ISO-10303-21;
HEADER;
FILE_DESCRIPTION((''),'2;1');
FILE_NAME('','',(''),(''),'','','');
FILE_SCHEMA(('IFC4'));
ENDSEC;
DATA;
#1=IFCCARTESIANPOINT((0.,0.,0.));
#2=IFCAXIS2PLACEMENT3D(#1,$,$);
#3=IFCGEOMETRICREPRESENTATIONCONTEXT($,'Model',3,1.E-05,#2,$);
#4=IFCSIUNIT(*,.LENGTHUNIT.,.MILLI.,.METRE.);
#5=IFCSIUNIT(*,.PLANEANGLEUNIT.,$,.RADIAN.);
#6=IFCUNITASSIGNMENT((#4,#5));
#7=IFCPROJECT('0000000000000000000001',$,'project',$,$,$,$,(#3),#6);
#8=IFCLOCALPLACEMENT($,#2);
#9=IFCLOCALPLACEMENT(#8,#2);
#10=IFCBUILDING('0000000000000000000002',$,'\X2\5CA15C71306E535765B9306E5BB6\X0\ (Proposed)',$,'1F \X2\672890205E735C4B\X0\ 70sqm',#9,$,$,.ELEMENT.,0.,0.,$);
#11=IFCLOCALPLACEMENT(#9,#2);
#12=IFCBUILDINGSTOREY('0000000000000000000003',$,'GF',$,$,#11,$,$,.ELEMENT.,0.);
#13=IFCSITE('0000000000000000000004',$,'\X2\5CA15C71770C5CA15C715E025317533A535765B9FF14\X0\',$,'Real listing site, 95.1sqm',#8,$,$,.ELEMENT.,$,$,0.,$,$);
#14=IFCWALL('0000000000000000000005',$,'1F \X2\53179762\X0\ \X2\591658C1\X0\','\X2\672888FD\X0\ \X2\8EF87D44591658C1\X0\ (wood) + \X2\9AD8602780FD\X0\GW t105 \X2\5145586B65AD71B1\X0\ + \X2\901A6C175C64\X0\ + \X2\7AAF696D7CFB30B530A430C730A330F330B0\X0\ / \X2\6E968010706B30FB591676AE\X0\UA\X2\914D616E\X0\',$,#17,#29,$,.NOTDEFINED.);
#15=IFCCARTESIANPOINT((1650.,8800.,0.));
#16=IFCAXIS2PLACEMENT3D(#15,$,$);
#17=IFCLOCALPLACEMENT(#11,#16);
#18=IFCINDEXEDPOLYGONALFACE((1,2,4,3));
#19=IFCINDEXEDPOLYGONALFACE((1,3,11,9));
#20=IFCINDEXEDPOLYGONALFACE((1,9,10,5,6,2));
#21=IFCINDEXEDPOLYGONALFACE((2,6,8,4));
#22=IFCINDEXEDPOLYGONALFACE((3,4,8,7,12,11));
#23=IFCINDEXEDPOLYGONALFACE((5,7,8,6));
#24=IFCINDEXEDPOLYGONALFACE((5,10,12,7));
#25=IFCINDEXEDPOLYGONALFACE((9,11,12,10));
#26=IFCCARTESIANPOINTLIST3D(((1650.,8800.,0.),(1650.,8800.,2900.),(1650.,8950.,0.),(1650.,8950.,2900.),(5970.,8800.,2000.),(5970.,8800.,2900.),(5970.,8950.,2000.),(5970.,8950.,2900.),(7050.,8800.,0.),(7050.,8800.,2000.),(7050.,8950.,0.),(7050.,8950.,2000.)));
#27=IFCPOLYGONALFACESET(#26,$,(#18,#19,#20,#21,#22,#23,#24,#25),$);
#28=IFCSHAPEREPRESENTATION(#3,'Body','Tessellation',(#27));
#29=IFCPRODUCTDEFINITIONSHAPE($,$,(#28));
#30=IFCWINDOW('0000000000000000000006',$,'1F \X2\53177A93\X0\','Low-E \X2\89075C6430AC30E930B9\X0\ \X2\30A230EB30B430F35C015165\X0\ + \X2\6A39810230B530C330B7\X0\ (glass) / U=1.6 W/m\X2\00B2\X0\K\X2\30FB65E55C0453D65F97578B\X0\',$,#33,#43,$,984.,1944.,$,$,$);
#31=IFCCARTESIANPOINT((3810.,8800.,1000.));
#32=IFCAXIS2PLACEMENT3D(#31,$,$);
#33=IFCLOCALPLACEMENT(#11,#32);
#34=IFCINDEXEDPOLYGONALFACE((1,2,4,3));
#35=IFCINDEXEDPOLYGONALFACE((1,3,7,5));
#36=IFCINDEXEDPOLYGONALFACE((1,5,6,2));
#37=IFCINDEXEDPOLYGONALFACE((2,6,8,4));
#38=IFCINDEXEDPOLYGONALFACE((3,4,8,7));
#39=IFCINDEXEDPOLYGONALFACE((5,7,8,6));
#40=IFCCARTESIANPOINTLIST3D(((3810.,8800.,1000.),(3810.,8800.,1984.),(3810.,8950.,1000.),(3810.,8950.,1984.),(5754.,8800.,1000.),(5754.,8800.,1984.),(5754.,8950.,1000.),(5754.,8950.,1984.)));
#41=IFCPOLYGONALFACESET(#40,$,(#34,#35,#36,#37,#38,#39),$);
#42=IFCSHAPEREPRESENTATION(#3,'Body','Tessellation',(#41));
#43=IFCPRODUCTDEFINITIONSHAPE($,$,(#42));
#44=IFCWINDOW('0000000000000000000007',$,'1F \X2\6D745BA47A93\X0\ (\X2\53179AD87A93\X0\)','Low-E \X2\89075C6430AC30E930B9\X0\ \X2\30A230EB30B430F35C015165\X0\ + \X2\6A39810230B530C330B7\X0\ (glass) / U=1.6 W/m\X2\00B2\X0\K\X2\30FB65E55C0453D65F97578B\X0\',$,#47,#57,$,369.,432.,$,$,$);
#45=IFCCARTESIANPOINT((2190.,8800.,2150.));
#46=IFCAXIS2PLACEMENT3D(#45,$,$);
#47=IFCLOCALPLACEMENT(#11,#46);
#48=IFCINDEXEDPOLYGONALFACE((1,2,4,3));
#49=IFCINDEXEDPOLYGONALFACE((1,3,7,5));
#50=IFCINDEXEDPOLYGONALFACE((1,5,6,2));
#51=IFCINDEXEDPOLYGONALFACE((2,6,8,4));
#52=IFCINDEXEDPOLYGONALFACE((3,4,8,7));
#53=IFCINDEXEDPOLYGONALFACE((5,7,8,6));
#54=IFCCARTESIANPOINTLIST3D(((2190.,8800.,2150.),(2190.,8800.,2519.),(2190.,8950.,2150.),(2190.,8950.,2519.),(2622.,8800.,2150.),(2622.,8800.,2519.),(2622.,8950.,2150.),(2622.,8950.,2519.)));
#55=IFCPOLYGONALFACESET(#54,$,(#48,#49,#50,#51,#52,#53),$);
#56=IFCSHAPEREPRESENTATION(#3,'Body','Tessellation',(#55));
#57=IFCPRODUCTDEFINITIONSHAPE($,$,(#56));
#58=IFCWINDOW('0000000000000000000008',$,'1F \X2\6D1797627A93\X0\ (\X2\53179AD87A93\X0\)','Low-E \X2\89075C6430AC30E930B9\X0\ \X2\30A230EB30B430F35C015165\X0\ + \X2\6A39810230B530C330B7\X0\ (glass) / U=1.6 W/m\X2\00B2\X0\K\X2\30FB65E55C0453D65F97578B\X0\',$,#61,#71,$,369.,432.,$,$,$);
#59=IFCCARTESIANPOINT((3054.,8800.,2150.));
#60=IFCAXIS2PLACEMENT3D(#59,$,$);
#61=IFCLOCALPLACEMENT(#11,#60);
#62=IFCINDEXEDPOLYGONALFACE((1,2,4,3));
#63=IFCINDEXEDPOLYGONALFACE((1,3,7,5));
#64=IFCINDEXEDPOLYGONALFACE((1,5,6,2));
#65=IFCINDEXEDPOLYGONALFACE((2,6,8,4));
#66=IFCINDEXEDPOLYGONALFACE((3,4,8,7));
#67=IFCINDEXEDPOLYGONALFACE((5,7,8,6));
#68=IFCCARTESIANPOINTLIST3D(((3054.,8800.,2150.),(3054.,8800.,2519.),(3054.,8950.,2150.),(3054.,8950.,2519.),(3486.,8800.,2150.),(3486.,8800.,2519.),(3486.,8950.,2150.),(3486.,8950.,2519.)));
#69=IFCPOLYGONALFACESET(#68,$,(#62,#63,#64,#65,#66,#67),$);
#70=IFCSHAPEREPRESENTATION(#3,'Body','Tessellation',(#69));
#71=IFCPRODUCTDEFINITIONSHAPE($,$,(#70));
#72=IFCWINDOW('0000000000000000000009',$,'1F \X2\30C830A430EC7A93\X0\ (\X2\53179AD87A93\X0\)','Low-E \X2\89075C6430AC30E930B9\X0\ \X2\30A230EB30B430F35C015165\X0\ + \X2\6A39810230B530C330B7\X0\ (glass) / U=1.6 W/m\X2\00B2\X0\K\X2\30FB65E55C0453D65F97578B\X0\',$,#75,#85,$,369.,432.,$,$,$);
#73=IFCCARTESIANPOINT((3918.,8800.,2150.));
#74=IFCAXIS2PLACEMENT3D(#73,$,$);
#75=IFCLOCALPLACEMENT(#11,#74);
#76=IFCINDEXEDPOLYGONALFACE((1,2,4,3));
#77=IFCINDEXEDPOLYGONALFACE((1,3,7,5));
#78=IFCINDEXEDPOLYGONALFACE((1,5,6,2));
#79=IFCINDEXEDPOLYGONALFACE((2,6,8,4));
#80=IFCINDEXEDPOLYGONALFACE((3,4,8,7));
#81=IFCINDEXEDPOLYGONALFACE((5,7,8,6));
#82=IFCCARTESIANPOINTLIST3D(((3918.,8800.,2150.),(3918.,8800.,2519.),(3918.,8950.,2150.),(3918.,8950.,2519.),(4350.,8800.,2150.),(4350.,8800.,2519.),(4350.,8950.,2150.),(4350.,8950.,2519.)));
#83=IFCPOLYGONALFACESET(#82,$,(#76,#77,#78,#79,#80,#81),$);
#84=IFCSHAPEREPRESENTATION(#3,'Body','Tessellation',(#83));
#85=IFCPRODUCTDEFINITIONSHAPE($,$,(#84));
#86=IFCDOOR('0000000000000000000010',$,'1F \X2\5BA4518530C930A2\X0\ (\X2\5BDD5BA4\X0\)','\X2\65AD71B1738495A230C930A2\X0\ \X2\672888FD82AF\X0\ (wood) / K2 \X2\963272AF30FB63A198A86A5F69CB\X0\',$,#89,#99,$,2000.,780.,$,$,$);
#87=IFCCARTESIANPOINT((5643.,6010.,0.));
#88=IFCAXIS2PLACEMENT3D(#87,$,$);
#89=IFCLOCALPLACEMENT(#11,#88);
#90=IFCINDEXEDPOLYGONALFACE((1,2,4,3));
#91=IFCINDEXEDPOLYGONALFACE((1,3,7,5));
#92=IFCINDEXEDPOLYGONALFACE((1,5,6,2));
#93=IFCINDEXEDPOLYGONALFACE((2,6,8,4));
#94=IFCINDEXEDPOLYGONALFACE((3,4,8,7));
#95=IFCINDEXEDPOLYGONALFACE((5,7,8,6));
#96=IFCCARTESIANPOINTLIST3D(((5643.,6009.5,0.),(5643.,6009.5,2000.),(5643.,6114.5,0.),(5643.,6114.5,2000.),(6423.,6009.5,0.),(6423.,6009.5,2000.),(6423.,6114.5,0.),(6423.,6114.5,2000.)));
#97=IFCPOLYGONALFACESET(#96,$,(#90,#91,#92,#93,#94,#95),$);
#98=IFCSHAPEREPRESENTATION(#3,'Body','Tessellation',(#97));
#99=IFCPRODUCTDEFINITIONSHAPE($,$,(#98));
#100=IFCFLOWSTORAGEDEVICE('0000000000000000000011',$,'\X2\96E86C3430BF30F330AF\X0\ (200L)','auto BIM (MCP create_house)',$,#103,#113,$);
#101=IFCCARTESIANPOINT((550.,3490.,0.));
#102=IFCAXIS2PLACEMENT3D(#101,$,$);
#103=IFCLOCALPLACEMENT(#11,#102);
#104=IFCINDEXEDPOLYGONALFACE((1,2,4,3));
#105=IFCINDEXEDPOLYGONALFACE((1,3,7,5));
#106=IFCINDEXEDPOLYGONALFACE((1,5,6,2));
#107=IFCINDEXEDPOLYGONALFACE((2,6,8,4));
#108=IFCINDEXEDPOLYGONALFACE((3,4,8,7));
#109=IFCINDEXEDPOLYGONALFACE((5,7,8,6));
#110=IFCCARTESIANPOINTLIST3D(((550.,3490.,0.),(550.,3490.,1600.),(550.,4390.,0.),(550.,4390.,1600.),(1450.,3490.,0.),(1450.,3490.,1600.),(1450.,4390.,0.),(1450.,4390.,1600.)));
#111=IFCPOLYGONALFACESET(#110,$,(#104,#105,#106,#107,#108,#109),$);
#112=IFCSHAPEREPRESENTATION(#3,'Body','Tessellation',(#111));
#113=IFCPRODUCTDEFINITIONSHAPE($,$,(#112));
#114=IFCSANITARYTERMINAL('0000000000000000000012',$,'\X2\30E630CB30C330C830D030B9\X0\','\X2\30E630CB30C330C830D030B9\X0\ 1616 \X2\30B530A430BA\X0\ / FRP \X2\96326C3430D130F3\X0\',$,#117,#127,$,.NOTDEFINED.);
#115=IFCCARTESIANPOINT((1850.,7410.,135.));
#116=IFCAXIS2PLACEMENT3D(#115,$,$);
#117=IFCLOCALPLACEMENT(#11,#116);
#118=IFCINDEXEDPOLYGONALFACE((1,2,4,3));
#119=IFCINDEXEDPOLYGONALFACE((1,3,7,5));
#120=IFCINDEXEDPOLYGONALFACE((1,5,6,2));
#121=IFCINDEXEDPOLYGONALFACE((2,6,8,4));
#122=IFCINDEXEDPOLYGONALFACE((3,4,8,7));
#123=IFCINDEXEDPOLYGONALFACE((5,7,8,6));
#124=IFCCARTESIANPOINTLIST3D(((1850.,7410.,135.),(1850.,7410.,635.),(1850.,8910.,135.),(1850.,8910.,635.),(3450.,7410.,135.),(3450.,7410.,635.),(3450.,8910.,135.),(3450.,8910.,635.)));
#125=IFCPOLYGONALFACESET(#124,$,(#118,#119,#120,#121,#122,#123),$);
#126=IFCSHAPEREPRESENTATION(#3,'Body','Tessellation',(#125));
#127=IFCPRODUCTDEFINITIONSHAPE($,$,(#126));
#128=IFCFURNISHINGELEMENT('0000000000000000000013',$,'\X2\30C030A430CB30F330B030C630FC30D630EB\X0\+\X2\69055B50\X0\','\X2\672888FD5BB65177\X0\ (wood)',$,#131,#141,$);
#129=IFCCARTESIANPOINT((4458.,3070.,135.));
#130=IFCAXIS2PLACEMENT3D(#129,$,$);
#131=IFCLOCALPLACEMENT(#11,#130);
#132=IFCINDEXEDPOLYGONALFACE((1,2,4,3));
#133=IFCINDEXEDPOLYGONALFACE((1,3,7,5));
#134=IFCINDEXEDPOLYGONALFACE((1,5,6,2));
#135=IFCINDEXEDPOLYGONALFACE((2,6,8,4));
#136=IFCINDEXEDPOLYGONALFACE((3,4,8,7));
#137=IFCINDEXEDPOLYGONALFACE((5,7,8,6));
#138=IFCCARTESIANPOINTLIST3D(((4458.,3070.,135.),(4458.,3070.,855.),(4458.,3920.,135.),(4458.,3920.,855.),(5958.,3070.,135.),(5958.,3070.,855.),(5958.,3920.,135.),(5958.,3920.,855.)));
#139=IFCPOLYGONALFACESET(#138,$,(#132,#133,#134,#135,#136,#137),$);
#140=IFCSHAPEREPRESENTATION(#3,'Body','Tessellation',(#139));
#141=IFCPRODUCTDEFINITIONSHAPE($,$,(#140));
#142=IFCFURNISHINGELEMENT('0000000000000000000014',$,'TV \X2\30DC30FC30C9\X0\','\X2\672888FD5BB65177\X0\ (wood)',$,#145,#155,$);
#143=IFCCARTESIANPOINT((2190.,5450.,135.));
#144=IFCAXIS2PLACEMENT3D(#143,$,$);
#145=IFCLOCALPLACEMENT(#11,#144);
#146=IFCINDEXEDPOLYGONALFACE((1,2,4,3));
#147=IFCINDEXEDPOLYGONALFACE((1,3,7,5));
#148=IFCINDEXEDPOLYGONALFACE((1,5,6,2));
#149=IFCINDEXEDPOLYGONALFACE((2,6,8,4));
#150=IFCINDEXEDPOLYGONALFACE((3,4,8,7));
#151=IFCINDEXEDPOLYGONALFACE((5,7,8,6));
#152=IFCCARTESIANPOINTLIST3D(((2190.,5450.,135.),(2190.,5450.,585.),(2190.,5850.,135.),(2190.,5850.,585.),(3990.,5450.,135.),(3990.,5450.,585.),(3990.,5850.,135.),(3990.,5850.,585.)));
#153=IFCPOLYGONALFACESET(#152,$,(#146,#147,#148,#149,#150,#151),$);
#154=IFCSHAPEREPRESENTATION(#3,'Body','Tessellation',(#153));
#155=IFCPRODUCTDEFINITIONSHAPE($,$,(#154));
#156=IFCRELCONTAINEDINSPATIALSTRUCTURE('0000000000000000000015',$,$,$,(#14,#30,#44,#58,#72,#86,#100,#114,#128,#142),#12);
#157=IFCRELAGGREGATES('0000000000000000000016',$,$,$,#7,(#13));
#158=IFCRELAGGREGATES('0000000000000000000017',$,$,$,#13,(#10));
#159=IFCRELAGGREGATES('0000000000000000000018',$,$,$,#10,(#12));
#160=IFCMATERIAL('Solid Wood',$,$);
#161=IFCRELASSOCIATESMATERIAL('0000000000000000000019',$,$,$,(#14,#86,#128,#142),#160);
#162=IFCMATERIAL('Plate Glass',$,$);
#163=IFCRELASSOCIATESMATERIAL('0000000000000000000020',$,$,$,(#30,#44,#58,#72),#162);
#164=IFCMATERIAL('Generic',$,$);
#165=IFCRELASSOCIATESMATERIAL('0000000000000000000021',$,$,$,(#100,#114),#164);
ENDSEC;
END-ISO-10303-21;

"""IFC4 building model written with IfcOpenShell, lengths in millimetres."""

from ifc_helpers import new_model, si_unit, frame, frame_2d, origin, place, context, project, spatial, rectangle, extrude, material, element, fill, save


model = new_model("IFC4")

# Units and contexts
model_context = context("Model", 3, precision=1e-05, world=origin())
ifc_project = project(units=[si_unit("LENGTHUNIT", "METRE", prefix="MILLI"), si_unit("PLANEANGLEUNIT", "RADIAN")], contexts=[model_context])

# Site, building, storey
site_placement = place(None, origin())
site = spatial("IfcSite", under=ifc_project, at=site_placement, Name="岡山県岡山市北区南方４", ObjectType="Real listing site, 95.1sqm", CompositionType="ELEMENT", RefElevation=0.0)
building_placement = place(site_placement, origin())
building = spatial("IfcBuilding", under=site, at=building_placement, Name="岡山の南方の家 (Proposed)", ObjectType="1F 木造平屋 70sqm", CompositionType="ELEMENT", ElevationOfRefHeight=0.0, ElevationOfTerrain=0.0)
storey_placement = place(building_placement, origin())
storey = spatial("IfcBuildingStorey", under=building, at=storey_placement, Name="GF", CompositionType="ELEMENT", Elevation=0.0)

# Wall, openings, windows
ifc_material_1 = material(Name="Solid Wood")
wall_1_placement = place(storey_placement, frame((1650.0, 8800.0, 0.0)))
wall_1 = element("IfcWall", 1, at=wall_1_placement, inside=storey, material=ifc_material_1, Name="1F 北面 外壁", Description="木製 軸組外壁 (wood) + 高性能GW t105 充填断熱 + 通気層 + 窯業系サイディング / 準耐火・外皮UA配慮", PredefinedType="NOTDEFINED", context=model_context, shape_type="SweptSolid", body=[
    extrude(rectangle(XDim=5400.0, YDim=150.0, at=frame_2d((2700.0, 75.0))), frame((1650.0, 8800.0, 0.0)), (0.0, 0.0, 1.0), 2900.0),
])
opening_1_placement = place(storey_placement, frame((3810.0, 8800.0, 1000.0)))
opening_1 = element("IfcOpeningElement", 2, at=opening_1_placement, cuts=wall_1, PredefinedType="NOTDEFINED", context=model_context, shape_type="SweptSolid", body=[
    extrude(rectangle(XDim=1944.0, YDim=150.0, at=frame_2d((972.0, 75.0))), frame((3810.0, 8800.0, 1000.0)), (0.0, 0.0, 1.0), 984.0),
])
opening_2_placement = place(storey_placement, frame((2190.0, 8800.0, 2150.0)))
opening_2 = element("IfcOpeningElement", 3, at=opening_2_placement, cuts=wall_1, PredefinedType="NOTDEFINED", context=model_context, shape_type="SweptSolid", body=[
    extrude(rectangle(XDim=432.0, YDim=150.0, at=frame_2d((216.0, 75.0))), frame((2190.0, 8800.0, 2150.0)), (0.0, 0.0, 1.0), 369.0),
])
opening_3_placement = place(storey_placement, frame((3054.0, 8800.0, 2150.0)))
opening_3 = element("IfcOpeningElement", 4, at=opening_3_placement, cuts=wall_1, PredefinedType="NOTDEFINED", context=model_context, shape_type="SweptSolid", body=[
    extrude(rectangle(XDim=432.0, YDim=150.0, at=frame_2d((216.0, 75.0))), frame((3054.0, 8800.0, 2150.0)), (0.0, 0.0, 1.0), 369.0),
])
opening_4_placement = place(storey_placement, frame((3918.0, 8800.0, 2150.0)))
opening_4 = element("IfcOpeningElement", 5, at=opening_4_placement, cuts=wall_1, PredefinedType="NOTDEFINED", context=model_context, shape_type="SweptSolid", body=[
    extrude(rectangle(XDim=432.0, YDim=150.0, at=frame_2d((216.0, 75.0))), frame((3918.0, 8800.0, 2150.0)), (0.0, 0.0, 1.0), 369.0),
])
ifc_material_2 = material(Name="Plate Glass")
window_1_placement = place(storey_placement, frame((3810.0, 8800.0, 1000.0)))
window_1 = element("IfcWindow", 6, at=window_1_placement, inside=storey, material=ifc_material_2, Name="1F 北窓", Description="Low-E 複層ガラス アルゴン封入 + 樹脂サッシ (glass) / U=1.6 W/m²K・日射取得型", OverallHeight=984.0, OverallWidth=1944.0, context=model_context, shape_type="SweptSolid", body=[
    extrude(rectangle(XDim=1944.0, YDim=150.0, at=frame_2d((972.0, 75.0))), frame((3810.0, 8800.0, 1000.0)), (0.0, 0.0, 1.0), 984.0),
])
fill(opening_1, window_1)
window_2_placement = place(storey_placement, frame((2190.0, 8800.0, 2150.0)))
window_2 = element("IfcWindow", 7, at=window_2_placement, inside=storey, material=ifc_material_2, Name="1F 浴室窓 (北高窓)", Description="Low-E 複層ガラス アルゴン封入 + 樹脂サッシ (glass) / U=1.6 W/m²K・日射取得型", OverallHeight=369.0, OverallWidth=432.0, context=model_context, shape_type="SweptSolid", body=[
    extrude(rectangle(XDim=432.0, YDim=150.0, at=frame_2d((216.0, 75.0))), frame((2190.0, 8800.0, 2150.0)), (0.0, 0.0, 1.0), 369.0),
])
fill(opening_2, window_2)
window_3_placement = place(storey_placement, frame((3054.0, 8800.0, 2150.0)))
window_3 = element("IfcWindow", 8, at=window_3_placement, inside=storey, material=ifc_material_2, Name="1F 洗面窓 (北高窓)", Description="Low-E 複層ガラス アルゴン封入 + 樹脂サッシ (glass) / U=1.6 W/m²K・日射取得型", OverallHeight=369.0, OverallWidth=432.0, context=model_context, shape_type="SweptSolid", body=[
    extrude(rectangle(XDim=432.0, YDim=150.0, at=frame_2d((216.0, 75.0))), frame((3054.0, 8800.0, 2150.0)), (0.0, 0.0, 1.0), 369.0),
])
fill(opening_3, window_3)
window_4_placement = place(storey_placement, frame((3918.0, 8800.0, 2150.0)))
window_4 = element("IfcWindow", 9, at=window_4_placement, inside=storey, material=ifc_material_2, Name="1F トイレ窓 (北高窓)", Description="Low-E 複層ガラス アルゴン封入 + 樹脂サッシ (glass) / U=1.6 W/m²K・日射取得型", OverallHeight=369.0, OverallWidth=432.0, context=model_context, shape_type="SweptSolid", body=[
    extrude(rectangle(XDim=432.0, YDim=150.0, at=frame_2d((216.0, 75.0))), frame((3918.0, 8800.0, 2150.0)), (0.0, 0.0, 1.0), 369.0),
])
fill(opening_4, window_4)

# Door
door_1_placement = place(storey_placement, frame((5643.0, 6010.0, 0.0)))
element("IfcDoor", 10, at=door_1_placement, inside=storey, material=ifc_material_1, Name="1F 室内ドア (寝室)", Description="断熱玄関ドア 木製芯 (wood) / K2 防犯・採風機構", OverallHeight=2000.0, OverallWidth=780.0, context=model_context, shape_type="SweptSolid", body=[
    extrude(rectangle(XDim=780.0, YDim=105.0, at=frame_2d((390.0, 52.0))), frame((5643.0, 6010.0, 0.0)), (0.0, 0.0, 1.0), 2000.0),
])

# Flow storage device
ifc_material_3 = material(Name="Generic")
flow_storage_device_placement = place(storey_placement, frame((550.0, 3490.0, 0.0)))
element("IfcFlowStorageDevice", 11, at=flow_storage_device_placement, inside=storey, material=ifc_material_3, Name="雨水タンク (200L)", Description="auto BIM (MCP create_house)", context=model_context, shape_type="SweptSolid", body=[
    extrude(rectangle(XDim=900.0, YDim=900.0, at=frame_2d((450.0, 450.0))), frame((550.0, 3490.0, 0.0)), (0.0, 0.0, 1.0), 1600.0),
])

# Sanitary terminal
sanitary_terminal_placement = place(storey_placement, frame((1850.0, 7410.0, 135.0)))
element("IfcSanitaryTerminal", 12, at=sanitary_terminal_placement, inside=storey, material=ifc_material_3, Name="ユニットバス", Description="ユニットバス 1616 サイズ / FRP 防水パン", PredefinedType="NOTDEFINED", context=model_context, shape_type="SweptSolid", body=[
    extrude(rectangle(XDim=1600.0, YDim=1500.0, at=frame_2d((800.0, 750.0))), frame((1850.0, 7410.0, 135.0)), (0.0, 0.0, 1.0), 500.0),
])

# Furnishing elements
furnishing_1_placement = place(storey_placement, frame((4458.0, 3070.0, 135.0)))
element("IfcFurnishingElement", 13, at=furnishing_1_placement, inside=storey, material=ifc_material_1, Name="ダイニングテーブル+椅子", Description="木製家具 (wood)", context=model_context, shape_type="SweptSolid", body=[
    extrude(rectangle(XDim=1500.0, YDim=850.0, at=frame_2d((750.0, 425.0))), frame((4458.0, 3070.0, 135.0)), (0.0, 0.0, 1.0), 720.0),
])
furnishing_2_placement = place(storey_placement, frame((2190.0, 5450.0, 135.0)))
element("IfcFurnishingElement", 14, at=furnishing_2_placement, inside=storey, material=ifc_material_1, Name="TV ボード", Description="木製家具 (wood)", context=model_context, shape_type="SweptSolid", body=[
    extrude(rectangle(XDim=1800.0, YDim=400.0, at=frame_2d((900.0, 200.0))), frame((2190.0, 5450.0, 135.0)), (0.0, 0.0, 1.0), 450.0),
])

save(model, "model.ifc")
